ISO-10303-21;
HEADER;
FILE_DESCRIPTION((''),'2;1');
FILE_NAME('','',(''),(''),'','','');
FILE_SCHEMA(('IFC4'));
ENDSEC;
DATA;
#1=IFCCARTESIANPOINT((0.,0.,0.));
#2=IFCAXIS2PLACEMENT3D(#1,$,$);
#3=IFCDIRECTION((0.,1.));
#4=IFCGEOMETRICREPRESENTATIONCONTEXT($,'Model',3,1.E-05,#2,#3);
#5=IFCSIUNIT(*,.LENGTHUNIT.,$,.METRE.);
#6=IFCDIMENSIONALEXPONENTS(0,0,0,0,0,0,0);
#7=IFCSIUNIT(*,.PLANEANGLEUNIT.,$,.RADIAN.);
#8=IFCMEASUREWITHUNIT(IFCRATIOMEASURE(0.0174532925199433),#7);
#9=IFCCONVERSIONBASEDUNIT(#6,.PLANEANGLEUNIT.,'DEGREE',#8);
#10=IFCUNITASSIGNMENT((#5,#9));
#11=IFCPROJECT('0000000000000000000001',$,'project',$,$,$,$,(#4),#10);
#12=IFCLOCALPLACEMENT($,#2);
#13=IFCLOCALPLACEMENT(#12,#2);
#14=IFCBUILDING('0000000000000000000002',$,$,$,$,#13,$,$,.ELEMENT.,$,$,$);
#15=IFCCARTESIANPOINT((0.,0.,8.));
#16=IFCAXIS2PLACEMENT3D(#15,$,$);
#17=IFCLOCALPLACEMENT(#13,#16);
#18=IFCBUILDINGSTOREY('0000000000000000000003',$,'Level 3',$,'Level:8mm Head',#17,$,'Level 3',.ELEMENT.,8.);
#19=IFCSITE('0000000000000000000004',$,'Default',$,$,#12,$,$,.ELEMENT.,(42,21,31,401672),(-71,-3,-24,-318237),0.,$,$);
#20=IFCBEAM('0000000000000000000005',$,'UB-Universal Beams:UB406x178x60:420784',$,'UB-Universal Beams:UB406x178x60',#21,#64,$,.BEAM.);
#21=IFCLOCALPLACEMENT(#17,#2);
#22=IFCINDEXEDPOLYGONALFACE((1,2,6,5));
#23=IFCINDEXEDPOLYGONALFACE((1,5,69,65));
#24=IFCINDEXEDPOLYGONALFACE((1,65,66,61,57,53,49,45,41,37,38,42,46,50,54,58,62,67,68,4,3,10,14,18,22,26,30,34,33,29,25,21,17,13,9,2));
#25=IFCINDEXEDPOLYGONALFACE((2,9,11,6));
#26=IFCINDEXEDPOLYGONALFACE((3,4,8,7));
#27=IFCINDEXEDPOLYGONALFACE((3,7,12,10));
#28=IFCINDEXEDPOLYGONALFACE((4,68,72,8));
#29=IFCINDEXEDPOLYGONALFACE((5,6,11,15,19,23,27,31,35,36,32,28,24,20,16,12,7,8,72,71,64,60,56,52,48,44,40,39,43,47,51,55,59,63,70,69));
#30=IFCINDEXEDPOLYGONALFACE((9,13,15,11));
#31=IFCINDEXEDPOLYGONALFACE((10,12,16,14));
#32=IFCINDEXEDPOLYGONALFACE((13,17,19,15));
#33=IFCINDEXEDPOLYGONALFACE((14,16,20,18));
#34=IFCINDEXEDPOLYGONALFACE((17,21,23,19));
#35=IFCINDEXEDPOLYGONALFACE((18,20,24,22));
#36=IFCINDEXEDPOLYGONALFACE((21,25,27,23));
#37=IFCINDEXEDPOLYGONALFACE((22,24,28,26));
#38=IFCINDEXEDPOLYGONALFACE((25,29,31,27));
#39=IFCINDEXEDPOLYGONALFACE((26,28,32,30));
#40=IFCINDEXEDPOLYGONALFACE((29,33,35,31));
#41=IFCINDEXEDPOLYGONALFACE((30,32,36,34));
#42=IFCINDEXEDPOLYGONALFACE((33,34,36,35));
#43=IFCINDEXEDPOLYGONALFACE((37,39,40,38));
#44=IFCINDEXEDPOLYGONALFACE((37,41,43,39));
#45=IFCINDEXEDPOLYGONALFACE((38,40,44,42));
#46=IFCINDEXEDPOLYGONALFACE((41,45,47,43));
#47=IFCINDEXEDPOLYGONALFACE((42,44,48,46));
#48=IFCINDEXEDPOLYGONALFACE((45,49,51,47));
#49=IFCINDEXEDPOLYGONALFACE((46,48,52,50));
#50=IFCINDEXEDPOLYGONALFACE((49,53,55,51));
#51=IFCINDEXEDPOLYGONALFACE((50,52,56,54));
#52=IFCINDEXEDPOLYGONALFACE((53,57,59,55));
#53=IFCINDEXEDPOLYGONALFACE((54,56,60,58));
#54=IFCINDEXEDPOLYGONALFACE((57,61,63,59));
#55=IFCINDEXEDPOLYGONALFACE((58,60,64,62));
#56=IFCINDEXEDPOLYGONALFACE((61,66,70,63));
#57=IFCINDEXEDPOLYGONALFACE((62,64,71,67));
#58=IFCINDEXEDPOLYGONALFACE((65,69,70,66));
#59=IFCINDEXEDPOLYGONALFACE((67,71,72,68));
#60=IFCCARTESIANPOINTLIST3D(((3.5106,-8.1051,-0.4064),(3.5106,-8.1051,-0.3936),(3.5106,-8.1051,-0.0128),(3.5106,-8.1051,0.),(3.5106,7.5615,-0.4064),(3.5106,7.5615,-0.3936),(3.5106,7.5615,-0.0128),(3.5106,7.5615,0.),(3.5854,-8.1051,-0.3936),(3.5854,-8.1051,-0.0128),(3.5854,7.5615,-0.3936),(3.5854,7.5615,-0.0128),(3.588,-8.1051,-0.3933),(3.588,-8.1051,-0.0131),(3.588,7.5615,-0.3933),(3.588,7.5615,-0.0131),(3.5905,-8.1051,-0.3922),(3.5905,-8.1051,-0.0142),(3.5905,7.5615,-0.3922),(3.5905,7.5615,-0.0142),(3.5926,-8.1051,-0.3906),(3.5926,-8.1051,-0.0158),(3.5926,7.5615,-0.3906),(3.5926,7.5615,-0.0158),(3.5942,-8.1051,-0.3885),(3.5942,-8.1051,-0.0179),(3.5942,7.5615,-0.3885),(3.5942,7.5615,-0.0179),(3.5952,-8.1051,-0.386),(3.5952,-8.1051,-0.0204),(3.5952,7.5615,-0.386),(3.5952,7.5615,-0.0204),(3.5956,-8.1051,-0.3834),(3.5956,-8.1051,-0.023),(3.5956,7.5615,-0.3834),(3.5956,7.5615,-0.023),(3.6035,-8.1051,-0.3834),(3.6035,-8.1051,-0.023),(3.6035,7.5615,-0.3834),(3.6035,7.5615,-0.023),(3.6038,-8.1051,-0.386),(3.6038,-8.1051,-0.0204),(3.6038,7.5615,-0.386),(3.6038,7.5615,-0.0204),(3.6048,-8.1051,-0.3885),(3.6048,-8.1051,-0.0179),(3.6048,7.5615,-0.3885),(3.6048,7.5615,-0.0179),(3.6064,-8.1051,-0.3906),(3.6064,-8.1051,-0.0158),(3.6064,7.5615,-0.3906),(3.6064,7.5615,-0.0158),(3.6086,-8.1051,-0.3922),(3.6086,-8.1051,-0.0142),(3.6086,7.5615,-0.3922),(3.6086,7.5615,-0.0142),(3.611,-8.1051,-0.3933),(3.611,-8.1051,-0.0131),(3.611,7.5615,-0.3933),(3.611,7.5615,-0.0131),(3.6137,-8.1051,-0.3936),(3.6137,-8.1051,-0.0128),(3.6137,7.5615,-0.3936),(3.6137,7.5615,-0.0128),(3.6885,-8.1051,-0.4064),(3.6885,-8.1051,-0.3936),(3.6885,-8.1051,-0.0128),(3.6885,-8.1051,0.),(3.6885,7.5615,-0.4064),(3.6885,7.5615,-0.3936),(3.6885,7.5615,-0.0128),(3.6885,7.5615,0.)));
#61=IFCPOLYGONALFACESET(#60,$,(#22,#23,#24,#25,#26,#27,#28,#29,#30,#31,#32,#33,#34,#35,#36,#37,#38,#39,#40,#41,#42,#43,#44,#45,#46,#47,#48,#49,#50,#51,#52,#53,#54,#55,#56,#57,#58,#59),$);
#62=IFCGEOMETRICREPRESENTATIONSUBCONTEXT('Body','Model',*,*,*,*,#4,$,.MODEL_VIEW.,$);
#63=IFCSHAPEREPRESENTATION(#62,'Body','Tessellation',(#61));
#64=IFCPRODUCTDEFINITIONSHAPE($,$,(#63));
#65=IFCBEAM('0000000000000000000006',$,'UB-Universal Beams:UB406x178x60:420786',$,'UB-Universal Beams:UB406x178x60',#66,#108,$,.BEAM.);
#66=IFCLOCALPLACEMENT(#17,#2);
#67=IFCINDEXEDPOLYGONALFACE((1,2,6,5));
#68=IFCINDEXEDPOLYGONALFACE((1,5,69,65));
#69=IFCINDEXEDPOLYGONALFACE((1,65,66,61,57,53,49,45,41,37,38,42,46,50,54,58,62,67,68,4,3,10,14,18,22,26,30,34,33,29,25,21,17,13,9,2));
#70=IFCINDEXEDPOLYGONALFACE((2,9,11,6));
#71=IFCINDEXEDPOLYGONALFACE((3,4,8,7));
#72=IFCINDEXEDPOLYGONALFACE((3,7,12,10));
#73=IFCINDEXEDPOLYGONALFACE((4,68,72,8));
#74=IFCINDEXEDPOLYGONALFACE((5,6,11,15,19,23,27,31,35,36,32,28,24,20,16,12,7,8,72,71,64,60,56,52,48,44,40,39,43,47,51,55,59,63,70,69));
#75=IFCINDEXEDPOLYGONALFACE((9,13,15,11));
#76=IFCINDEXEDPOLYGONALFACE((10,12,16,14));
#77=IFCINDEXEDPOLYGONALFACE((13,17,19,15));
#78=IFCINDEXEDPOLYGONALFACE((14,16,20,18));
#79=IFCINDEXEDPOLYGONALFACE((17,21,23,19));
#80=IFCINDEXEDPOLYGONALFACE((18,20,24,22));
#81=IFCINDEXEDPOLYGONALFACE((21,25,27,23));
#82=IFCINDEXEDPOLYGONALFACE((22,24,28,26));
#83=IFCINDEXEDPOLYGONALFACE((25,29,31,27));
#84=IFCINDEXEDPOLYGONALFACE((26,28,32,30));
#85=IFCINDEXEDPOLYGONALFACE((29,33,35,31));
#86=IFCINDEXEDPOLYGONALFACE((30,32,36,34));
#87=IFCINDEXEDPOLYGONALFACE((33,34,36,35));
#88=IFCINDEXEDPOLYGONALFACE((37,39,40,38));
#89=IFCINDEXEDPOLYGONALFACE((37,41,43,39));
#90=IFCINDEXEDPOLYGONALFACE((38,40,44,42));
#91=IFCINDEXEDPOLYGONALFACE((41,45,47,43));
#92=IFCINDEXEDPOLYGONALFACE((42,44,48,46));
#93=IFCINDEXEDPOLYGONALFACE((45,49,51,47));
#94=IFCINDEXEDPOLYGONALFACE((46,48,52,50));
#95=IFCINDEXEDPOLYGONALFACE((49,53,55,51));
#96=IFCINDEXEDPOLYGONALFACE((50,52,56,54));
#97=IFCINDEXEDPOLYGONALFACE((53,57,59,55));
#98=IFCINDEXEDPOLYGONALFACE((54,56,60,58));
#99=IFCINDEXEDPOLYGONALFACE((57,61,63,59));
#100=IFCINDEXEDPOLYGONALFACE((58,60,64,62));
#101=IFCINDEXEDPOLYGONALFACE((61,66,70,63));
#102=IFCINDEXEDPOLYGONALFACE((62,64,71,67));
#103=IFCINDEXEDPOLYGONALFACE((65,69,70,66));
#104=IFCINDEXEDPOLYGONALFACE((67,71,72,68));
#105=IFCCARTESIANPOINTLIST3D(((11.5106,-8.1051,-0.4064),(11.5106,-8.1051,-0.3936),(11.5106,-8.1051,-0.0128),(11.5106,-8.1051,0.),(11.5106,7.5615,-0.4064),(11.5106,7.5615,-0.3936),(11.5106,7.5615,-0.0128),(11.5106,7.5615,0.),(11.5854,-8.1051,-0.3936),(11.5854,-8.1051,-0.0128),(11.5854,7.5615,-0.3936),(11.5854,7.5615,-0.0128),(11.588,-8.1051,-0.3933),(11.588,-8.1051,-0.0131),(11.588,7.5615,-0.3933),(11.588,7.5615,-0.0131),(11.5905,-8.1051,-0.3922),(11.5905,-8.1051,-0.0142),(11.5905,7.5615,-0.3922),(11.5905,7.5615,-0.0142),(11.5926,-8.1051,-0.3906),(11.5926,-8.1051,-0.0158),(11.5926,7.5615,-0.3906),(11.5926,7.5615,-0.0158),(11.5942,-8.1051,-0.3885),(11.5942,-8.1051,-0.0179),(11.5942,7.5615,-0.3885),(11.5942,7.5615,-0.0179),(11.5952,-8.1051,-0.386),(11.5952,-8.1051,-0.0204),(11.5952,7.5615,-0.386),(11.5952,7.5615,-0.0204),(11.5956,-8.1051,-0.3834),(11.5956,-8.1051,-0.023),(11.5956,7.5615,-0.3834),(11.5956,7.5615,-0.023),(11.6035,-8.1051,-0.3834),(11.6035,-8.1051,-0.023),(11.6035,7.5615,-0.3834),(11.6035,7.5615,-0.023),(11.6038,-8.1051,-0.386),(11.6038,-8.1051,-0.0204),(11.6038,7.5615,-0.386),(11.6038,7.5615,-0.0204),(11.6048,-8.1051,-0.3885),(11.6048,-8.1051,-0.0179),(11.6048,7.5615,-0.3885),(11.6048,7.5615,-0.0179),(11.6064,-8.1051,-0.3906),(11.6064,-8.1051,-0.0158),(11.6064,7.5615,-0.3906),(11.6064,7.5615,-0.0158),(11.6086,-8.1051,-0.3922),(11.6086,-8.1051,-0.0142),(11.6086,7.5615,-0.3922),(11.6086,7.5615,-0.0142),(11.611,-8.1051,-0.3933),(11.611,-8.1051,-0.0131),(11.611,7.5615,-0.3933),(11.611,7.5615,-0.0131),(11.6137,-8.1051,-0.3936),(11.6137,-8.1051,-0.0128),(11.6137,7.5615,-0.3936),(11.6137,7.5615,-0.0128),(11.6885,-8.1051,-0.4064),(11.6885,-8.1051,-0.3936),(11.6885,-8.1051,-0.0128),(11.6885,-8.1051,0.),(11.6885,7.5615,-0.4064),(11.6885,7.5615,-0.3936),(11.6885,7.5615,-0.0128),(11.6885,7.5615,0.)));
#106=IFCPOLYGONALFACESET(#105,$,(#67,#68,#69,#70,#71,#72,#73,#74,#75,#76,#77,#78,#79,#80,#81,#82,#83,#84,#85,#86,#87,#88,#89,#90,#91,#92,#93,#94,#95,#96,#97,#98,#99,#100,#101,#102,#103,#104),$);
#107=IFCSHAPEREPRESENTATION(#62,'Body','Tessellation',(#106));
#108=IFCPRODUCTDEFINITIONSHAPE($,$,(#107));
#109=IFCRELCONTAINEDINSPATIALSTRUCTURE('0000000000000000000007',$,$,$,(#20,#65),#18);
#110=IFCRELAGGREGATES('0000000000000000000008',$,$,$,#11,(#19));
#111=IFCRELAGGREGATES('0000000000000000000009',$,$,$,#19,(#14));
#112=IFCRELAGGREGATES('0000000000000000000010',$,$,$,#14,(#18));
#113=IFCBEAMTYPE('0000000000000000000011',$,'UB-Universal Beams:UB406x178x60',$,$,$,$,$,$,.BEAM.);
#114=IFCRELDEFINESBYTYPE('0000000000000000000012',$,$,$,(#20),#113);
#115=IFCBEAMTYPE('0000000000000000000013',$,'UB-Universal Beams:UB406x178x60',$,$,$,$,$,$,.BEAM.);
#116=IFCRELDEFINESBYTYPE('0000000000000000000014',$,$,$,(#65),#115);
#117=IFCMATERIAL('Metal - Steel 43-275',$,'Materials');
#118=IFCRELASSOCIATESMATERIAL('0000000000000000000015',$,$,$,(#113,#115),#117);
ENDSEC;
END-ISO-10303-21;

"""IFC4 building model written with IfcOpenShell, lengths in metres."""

from ifc_helpers import new_model, entity, si_unit, converted_unit, direction, frame, frame_2d, origin, place, context, subcontext, project, spatial, i_section, extrude, source, transform, mapped, material, material_profile, profile_set, type_object, type_shapes, element, save


model = new_model("IFC4")

# Units and contexts
model_context = context("Model", 3, precision=1e-05, world=origin(), true_north=direction((0.0, 1.0)))
body_context = subcontext(model_context, "Body", "Model", "MODEL_VIEW")
ifc_project = project(units=[si_unit("LENGTHUNIT", "METRE"), converted_unit("PLANEANGLEUNIT", "DEGREE", entity("IfcRatioMeasure", 0.0174532925199433), si_unit("PLANEANGLEUNIT", "RADIAN"), dimensions=[0, 0, 0, 0, 0, 0, 0])], contexts=[model_context])

# Site, building, storey
site_placement = place(None, origin())
site = spatial("IfcSite", under=ifc_project, at=site_placement, Name="Default", CompositionType="ELEMENT", RefLatitude=(42, 21, 31, 401672), RefLongitude=(-71, -3, -24, -318237), RefElevation=0.0)
building_placement = place(site_placement, origin())
building = spatial("IfcBuilding", under=site, at=building_placement, CompositionType="ELEMENT")
storey_placement = place(building_placement, frame((0.0, 0.0, 8.0)))
storey = spatial("IfcBuildingStorey", under=building, at=storey_placement, Name="Level 3", ObjectType="Level:8mm Head", LongName="Level 3", CompositionType="ELEMENT", Elevation=8.0)

# Shared definitions
ifc_material_1 = material(Name="Metal - Steel 43-275", Category="Materials")
ifc_material_profile_1 = material_profile(ifc_material_1, i_section(OverallWidth=0.1779, OverallDepth=0.4064, WebThickness=0.0079, FlangeThickness=0.0128, FilletRadius=0.0102, at=frame_2d((0.0, 0.0), x_axis=(0.0, 1.0))), Name="UB406x178x60")
ifc_profile_set_1 = profile_set([ifc_material_profile_1], Name="UB406x178x60")

# Beams
beam_type_1 = type_object("IfcBeamType", Name="UB-Universal Beams:UB406x178x60", PredefinedType="BEAM", material=ifc_profile_set_1)
shared_shape_1 = source(origin(), body_context, "Body", "SweptSolid", [
    extrude(i_section(OverallWidth=0.1779, OverallDepth=0.4064, WebThickness=0.0079, FlangeThickness=0.0128, FilletRadius=0.0102, at=frame_2d((0.0, 0.0), x_axis=(1.0, 0.0))), frame((3.5995, -8.1051, 7.7968), z_axis=(0.0, 1.0, 0.0), x_axis=(-1.0, 0.0, 0.0)), (0.0, 0.0, 1.0), 15.6666),
])
type_shapes(beam_type_1, [shared_shape_1])
beam_1_placement = place(storey_placement, frame((0.0, 0.0, -8.0)))
element("IfcBeam", 1, at=beam_1_placement, inside=storey, type_object=beam_type_1, Name="UB-Universal Beams:UB406x178x60:420784", ObjectType="UB-Universal Beams:UB406x178x60", PredefinedType="BEAM", context=body_context, shape_type="MappedRepresentation", body=[
    mapped(shared_shape_1, transform((0.0, 0.0, 0.0), scale=1.0)),
])
beam_type_2 = type_object("IfcBeamType", Name="UB-Universal Beams:UB406x178x60", PredefinedType="BEAM", material=ifc_profile_set_1)
shared_shape_2 = source(origin(), body_context, "Body", "SweptSolid", [
    extrude(i_section(OverallWidth=0.1779, OverallDepth=0.4064, WebThickness=0.0079, FlangeThickness=0.0128, FilletRadius=0.0102, at=frame_2d((0.0, 0.0), x_axis=(1.0, 0.0))), frame((11.5995, -8.1051, 7.7968), z_axis=(0.0, 1.0, 0.0), x_axis=(-1.0, 0.0, 0.0)), (0.0, 0.0, 1.0), 15.6666),
])
type_shapes(beam_type_2, [shared_shape_2])
beam_2_placement = place(storey_placement, frame((0.0, 0.0, -8.0)))
element("IfcBeam", 2, at=beam_2_placement, inside=storey, type_object=beam_type_2, Name="UB-Universal Beams:UB406x178x60:420786", ObjectType="UB-Universal Beams:UB406x178x60", PredefinedType="BEAM", context=body_context, shape_type="MappedRepresentation", body=[
    mapped(shared_shape_2, transform((0.0, 0.0, 0.0), scale=1.0)),
])

save(model, "model.ifc")
